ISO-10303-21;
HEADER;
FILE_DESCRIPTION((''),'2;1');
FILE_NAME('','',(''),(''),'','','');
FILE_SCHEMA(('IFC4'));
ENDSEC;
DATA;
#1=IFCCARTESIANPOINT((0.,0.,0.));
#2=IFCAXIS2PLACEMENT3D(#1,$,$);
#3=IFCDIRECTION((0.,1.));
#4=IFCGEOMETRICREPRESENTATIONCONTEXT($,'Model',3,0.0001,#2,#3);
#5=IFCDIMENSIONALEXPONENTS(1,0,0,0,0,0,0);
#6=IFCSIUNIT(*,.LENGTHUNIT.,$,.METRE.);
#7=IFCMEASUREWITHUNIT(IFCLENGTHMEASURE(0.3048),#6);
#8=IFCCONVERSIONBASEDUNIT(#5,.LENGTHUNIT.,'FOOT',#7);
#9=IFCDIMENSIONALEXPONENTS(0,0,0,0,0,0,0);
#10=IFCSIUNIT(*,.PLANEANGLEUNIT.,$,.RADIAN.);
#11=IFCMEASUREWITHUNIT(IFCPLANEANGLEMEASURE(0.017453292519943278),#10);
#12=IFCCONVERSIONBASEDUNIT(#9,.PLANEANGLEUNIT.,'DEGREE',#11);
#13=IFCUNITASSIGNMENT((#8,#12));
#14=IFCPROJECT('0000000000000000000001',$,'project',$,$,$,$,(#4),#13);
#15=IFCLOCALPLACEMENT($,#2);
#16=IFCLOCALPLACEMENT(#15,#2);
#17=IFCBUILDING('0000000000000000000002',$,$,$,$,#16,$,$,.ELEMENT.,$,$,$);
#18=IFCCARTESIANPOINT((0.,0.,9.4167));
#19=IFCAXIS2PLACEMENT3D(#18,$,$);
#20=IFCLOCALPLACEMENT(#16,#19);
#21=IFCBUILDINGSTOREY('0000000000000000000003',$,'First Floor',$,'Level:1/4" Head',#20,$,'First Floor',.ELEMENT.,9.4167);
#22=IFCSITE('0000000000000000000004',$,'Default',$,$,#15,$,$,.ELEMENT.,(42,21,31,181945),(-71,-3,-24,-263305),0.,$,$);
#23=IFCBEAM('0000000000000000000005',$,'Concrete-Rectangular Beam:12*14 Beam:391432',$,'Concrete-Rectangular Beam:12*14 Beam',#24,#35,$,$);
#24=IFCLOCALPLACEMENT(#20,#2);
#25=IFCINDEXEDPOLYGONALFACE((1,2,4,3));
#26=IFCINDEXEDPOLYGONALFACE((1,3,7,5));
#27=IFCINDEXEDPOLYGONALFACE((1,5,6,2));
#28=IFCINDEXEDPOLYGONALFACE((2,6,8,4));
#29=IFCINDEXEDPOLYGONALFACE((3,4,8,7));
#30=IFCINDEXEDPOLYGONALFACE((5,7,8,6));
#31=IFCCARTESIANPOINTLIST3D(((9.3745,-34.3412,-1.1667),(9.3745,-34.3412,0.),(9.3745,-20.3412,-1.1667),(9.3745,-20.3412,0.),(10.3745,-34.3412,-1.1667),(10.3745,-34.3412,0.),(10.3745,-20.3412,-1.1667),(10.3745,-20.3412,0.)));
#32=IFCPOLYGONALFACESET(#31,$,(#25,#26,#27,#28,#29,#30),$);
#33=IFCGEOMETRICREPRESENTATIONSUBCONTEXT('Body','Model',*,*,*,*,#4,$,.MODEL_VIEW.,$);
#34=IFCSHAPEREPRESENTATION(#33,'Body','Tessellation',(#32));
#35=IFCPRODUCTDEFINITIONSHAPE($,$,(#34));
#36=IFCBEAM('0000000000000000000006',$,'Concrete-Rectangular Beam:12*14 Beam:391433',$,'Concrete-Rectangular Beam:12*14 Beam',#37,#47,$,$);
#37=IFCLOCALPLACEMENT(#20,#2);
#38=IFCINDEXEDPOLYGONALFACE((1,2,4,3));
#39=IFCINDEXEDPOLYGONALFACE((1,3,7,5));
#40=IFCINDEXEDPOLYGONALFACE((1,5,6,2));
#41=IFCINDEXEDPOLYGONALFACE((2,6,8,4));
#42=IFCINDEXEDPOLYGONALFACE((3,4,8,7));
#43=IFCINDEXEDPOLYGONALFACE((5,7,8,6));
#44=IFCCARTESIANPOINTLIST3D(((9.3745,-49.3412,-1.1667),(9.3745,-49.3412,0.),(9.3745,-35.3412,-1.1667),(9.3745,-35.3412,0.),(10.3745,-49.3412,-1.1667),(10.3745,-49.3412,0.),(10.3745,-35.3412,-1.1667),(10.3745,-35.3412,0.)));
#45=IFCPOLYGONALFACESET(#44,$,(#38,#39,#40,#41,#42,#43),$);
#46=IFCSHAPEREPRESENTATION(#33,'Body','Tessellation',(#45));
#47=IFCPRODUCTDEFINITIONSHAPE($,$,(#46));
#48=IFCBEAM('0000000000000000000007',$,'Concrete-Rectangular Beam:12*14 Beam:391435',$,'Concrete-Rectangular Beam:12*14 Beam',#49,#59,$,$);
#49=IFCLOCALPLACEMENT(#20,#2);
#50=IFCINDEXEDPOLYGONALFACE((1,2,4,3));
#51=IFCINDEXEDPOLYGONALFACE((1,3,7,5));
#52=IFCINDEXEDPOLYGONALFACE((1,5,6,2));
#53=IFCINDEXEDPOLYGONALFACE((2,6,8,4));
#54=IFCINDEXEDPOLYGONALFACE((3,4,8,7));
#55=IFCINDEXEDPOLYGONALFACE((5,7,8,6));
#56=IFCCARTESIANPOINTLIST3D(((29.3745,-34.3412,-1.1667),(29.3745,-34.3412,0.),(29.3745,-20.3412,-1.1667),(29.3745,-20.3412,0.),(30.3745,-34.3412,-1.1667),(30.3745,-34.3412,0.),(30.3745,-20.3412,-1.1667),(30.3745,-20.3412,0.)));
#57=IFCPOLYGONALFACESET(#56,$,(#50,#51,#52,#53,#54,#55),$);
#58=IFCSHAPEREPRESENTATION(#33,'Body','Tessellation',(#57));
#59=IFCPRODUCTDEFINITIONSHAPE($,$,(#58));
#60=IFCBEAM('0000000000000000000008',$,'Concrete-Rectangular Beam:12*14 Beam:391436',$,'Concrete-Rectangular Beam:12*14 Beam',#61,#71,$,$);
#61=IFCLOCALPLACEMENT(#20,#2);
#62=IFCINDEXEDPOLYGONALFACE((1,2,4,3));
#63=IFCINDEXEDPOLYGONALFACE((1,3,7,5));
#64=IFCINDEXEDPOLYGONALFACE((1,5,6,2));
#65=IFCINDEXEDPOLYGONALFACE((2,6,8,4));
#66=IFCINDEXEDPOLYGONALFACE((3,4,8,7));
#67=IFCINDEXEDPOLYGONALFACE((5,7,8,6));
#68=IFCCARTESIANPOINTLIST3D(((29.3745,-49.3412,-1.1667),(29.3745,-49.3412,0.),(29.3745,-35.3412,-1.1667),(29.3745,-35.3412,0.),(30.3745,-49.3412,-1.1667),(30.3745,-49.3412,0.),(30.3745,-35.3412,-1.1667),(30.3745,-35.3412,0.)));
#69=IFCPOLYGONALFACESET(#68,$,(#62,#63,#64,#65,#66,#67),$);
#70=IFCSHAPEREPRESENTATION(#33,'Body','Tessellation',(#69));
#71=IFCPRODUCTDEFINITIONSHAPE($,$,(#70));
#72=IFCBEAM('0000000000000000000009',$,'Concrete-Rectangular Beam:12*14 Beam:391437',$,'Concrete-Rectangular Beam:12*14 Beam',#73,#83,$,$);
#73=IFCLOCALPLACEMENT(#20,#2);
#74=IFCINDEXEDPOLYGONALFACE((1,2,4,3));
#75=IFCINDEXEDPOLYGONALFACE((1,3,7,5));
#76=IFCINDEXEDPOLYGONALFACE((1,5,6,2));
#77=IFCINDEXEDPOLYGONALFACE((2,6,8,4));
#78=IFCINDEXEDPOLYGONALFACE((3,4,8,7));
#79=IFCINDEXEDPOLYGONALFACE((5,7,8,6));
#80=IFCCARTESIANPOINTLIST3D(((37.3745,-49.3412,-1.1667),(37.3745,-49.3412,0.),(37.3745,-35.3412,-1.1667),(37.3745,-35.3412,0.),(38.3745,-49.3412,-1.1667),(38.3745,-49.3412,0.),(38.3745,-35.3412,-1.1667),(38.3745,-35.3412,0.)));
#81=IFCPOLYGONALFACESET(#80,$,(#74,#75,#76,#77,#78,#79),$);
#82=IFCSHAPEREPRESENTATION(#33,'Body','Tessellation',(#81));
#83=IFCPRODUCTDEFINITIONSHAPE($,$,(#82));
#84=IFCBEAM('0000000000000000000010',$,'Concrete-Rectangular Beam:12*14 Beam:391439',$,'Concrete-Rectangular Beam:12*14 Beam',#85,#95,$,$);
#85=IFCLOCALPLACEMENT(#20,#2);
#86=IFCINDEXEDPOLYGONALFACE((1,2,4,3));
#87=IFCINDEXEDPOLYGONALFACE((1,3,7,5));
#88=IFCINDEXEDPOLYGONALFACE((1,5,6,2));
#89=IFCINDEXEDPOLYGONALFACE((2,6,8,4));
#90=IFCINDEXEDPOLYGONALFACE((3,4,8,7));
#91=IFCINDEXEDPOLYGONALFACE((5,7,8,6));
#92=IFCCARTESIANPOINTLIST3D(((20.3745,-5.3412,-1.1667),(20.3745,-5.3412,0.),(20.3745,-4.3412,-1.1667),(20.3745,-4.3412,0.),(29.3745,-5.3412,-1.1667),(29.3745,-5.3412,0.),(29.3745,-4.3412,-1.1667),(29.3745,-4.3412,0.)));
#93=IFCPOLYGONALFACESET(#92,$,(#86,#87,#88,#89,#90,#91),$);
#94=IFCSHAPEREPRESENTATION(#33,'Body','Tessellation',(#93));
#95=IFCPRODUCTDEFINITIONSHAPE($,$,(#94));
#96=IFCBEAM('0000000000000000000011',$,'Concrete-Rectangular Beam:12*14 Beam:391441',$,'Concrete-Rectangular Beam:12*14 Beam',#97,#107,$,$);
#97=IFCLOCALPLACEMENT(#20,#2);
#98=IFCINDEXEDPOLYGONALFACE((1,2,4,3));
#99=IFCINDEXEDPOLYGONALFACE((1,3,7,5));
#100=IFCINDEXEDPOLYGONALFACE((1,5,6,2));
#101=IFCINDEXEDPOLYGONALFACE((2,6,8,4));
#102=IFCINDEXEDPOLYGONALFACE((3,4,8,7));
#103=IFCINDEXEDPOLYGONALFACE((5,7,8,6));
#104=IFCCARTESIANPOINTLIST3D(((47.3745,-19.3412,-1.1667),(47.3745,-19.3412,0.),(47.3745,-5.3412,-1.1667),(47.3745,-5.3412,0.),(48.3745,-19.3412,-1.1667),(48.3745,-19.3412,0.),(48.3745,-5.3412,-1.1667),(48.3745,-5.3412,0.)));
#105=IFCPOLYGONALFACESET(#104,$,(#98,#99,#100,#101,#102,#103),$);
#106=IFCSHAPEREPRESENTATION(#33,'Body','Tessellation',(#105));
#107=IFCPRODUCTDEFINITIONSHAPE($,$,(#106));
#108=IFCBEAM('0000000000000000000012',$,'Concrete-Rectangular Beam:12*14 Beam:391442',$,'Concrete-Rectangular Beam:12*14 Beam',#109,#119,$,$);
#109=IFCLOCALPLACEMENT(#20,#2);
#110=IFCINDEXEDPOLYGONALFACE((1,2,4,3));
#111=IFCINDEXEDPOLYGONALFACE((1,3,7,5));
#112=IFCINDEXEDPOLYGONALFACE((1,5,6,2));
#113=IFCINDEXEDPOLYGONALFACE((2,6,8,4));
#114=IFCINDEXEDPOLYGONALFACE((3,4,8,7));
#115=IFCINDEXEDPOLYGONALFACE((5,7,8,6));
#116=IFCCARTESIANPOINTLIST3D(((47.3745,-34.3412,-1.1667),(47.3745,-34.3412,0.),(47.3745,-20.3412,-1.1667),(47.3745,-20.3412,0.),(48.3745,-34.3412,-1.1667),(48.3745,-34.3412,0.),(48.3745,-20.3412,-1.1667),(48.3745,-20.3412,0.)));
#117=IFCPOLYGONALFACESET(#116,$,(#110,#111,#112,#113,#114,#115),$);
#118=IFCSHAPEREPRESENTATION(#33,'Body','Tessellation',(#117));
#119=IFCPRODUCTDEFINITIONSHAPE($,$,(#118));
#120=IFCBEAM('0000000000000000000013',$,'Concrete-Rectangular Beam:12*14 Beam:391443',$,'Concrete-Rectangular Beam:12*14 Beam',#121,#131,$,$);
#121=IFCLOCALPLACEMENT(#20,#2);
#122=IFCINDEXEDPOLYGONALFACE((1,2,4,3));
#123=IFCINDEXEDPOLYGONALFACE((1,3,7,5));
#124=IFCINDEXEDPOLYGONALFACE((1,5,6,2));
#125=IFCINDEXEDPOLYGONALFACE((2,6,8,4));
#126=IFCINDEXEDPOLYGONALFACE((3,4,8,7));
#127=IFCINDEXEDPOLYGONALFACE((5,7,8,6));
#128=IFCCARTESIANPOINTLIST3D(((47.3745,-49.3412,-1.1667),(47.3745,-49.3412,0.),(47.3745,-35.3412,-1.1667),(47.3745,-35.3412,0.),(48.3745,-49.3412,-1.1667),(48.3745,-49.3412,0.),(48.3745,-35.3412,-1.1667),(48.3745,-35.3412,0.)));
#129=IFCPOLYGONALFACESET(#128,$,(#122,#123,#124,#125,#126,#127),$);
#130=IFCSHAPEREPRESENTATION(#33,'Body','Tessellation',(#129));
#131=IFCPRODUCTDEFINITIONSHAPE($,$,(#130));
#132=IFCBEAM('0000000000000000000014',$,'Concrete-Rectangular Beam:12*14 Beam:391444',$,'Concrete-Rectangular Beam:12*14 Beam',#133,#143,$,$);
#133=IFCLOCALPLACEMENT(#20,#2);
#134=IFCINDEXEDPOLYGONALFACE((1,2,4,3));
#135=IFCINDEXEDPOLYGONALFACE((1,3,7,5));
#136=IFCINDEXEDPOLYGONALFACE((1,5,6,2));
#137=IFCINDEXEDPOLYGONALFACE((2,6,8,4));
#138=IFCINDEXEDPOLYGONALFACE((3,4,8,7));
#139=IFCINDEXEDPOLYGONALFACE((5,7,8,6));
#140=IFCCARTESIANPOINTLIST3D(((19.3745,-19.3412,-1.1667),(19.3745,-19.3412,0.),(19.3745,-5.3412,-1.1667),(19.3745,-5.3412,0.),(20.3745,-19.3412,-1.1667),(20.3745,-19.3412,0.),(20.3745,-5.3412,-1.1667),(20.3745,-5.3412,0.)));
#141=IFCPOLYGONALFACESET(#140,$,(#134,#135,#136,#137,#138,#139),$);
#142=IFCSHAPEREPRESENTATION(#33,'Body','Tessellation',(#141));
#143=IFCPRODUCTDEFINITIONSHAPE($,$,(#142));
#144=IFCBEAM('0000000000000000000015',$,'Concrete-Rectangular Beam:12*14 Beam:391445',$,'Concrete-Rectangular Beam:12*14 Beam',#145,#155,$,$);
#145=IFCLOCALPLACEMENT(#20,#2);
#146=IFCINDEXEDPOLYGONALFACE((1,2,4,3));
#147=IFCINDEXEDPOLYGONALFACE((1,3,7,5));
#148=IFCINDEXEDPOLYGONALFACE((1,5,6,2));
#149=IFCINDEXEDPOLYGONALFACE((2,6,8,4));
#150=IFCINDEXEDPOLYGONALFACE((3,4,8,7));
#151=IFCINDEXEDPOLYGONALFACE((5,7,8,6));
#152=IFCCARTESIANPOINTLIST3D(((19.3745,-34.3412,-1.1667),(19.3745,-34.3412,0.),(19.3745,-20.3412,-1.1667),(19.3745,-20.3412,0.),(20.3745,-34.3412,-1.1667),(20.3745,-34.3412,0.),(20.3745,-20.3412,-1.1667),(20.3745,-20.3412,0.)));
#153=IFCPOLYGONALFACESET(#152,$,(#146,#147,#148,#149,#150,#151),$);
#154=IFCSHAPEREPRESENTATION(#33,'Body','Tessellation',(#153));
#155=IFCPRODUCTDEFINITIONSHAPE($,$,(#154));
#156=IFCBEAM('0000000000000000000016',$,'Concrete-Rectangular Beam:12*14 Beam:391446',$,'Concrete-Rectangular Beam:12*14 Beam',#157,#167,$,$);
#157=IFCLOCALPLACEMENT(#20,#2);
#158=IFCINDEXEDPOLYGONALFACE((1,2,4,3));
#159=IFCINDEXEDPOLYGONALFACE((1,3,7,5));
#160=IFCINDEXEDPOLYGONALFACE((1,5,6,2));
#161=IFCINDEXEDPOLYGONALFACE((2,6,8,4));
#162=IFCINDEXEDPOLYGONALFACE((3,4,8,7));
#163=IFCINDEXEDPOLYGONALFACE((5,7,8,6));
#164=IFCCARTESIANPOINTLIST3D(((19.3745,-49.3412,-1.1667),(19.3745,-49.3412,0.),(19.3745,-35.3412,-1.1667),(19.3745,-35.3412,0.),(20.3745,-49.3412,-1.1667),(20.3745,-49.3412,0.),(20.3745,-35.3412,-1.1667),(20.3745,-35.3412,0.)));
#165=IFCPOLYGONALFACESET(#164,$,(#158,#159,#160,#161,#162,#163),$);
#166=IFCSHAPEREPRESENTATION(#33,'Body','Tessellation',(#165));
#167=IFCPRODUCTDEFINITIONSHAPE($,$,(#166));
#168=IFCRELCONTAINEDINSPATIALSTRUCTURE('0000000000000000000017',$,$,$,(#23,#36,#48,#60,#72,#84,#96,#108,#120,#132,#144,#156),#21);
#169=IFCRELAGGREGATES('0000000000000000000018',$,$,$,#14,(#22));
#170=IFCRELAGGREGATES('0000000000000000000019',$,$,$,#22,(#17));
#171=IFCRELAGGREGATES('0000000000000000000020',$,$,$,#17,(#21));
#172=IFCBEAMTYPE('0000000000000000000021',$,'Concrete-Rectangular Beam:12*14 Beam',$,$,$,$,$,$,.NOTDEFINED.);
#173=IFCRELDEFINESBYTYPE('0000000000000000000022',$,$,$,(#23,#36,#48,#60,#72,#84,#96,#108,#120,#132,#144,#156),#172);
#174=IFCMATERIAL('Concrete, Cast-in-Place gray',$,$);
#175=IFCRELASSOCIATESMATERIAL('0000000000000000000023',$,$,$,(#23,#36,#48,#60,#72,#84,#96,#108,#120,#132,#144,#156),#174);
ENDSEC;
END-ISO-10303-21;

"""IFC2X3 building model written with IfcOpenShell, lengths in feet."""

from ifc_helpers import new_model, entity, si_unit, converted_unit, direction, frame, frame_2d, origin, place, context, subcontext, project, spatial, rectangle, extrude, material, type_object, element, save


model = new_model("IFC2X3")

# Units and contexts
model_context = context("Model", 3, precision=0.0001, world=origin(), true_north=direction((0.0, 1.0)))
body_context = subcontext(model_context, "Body", "Model", "MODEL_VIEW")
ifc_project = project(units=[converted_unit("LENGTHUNIT", "FOOT", entity("IfcLengthMeasure", 0.3048), si_unit("LENGTHUNIT", "METRE"), dimensions=[1, 0, 0, 0, 0, 0, 0]), converted_unit("PLANEANGLEUNIT", "DEGREE", entity("IfcPlaneAngleMeasure", 0.017453292519943278), si_unit("PLANEANGLEUNIT", "RADIAN"), dimensions=[0, 0, 0, 0, 0, 0, 0])], contexts=[model_context])

# Site, building, storey
site_placement = place(None, origin())
site = spatial("IfcSite", under=ifc_project, at=site_placement, Name="Default", CompositionType="ELEMENT", RefLatitude=(42, 21, 31, 181945), RefLongitude=(-71, -3, -24, -263305), RefElevation=0.0)
building_placement = place(site_placement, origin())
building = spatial("IfcBuilding", under=site, at=building_placement, CompositionType="ELEMENT")
storey_placement = place(building_placement, frame((0.0, 0.0, 9.4167)))
storey = spatial("IfcBuildingStorey", under=building, at=storey_placement, Name="First Floor", ObjectType="Level:1/4\" Head", LongName="First Floor", CompositionType="ELEMENT", Elevation=9.4167)

# Beams
ifc_material = material(Name="Concrete, Cast-in-Place gray")
beam_type = type_object("IfcBeamType", Name="Concrete-Rectangular Beam:12*14 Beam", PredefinedType="NOTDEFINED")
beam_1_placement = place(storey_placement, frame((9.8745, -19.8412, 0.0), z_axis=(0.0, 0.0, 1.0), x_axis=(0.0, -1.0, 0.0)))
element("IfcBeam", 1, at=beam_1_placement, inside=storey, type_object=beam_type, material=ifc_material, Name="Concrete-Rectangular Beam:12*14 Beam:391432", ObjectType="Concrete-Rectangular Beam:12*14 Beam", context=body_context, shape_type="SweptSolid", body=[
    extrude(rectangle(XDim=1.1667, YDim=1.0, at=frame_2d((0.0, 0.0), x_axis=(1.0, 0.0))), frame((0.5, 0.0, -0.5833), z_axis=(1.0, 0.0, 0.0), x_axis=(0.0, 0.0, -1.0)), (0.0, 0.0, 1.0), 14.0),
])
beam_2_placement = place(storey_placement, frame((9.8745, -34.8412, 0.0), z_axis=(0.0, 0.0, 1.0), x_axis=(0.0, -1.0, 0.0)))
element("IfcBeam", 2, at=beam_2_placement, inside=storey, type_object=beam_type, material=ifc_material, Name="Concrete-Rectangular Beam:12*14 Beam:391433", ObjectType="Concrete-Rectangular Beam:12*14 Beam", context=body_context, shape_type="SweptSolid", body=[
    extrude(rectangle(XDim=1.1667, YDim=1.0, at=frame_2d((0.0, 0.0), x_axis=(1.0, 0.0))), frame((0.5, 0.0, -0.5833), z_axis=(1.0, 0.0, 0.0), x_axis=(0.0, 0.0, -1.0)), (0.0, 0.0, 1.0), 14.0),
])
beam_3_placement = place(storey_placement, frame((29.8745, -19.8412, 0.0), z_axis=(0.0, 0.0, 1.0), x_axis=(0.0, -1.0, 0.0)))
element("IfcBeam", 3, at=beam_3_placement, inside=storey, type_object=beam_type, material=ifc_material, Name="Concrete-Rectangular Beam:12*14 Beam:391435", ObjectType="Concrete-Rectangular Beam:12*14 Beam", context=body_context, shape_type="SweptSolid", body=[
    extrude(rectangle(XDim=1.1667, YDim=1.0, at=frame_2d((0.0, 0.0), x_axis=(1.0, 0.0))), frame((0.5, 0.0, -0.5833), z_axis=(1.0, 0.0, 0.0), x_axis=(0.0, 0.0, -1.0)), (0.0, 0.0, 1.0), 14.0),
])
beam_4_placement = place(storey_placement, frame((29.8745, -34.8412, 0.0), z_axis=(0.0, 0.0, 1.0), x_axis=(0.0, -1.0, 0.0)))
element("IfcBeam", 4, at=beam_4_placement, inside=storey, type_object=beam_type, material=ifc_material, Name="Concrete-Rectangular Beam:12*14 Beam:391436", ObjectType="Concrete-Rectangular Beam:12*14 Beam", context=body_context, shape_type="SweptSolid", body=[
    extrude(rectangle(XDim=1.1667, YDim=1.0, at=frame_2d((0.0, 0.0), x_axis=(1.0, 0.0))), frame((0.5, 0.0, -0.5833), z_axis=(1.0, 0.0, 0.0), x_axis=(0.0, 0.0, -1.0)), (0.0, 0.0, 1.0), 14.0),
])
beam_5_placement = place(storey_placement, frame((37.8745, -34.8412, 0.0), z_axis=(0.0, 0.0, 1.0), x_axis=(0.0, -1.0, 0.0)))
element("IfcBeam", 5, at=beam_5_placement, inside=storey, type_object=beam_type, material=ifc_material, Name="Concrete-Rectangular Beam:12*14 Beam:391437", ObjectType="Concrete-Rectangular Beam:12*14 Beam", context=body_context, shape_type="SweptSolid", body=[
    extrude(rectangle(XDim=1.1667, YDim=1.0, at=frame_2d((0.0, 0.0), x_axis=(1.0, 0.0))), frame((0.5, 0.0, -0.5833), z_axis=(1.0, 0.0, 0.0), x_axis=(0.0, 0.0, -1.0)), (0.0, 0.0, 1.0), 14.0),
])
beam_6_placement = place(storey_placement, frame((19.8745, -4.8412, 0.0)))
element("IfcBeam", 6, at=beam_6_placement, inside=storey, type_object=beam_type, material=ifc_material, Name="Concrete-Rectangular Beam:12*14 Beam:391439", ObjectType="Concrete-Rectangular Beam:12*14 Beam", context=body_context, shape_type="SweptSolid", body=[
    extrude(rectangle(XDim=1.1667, YDim=1.0, at=frame_2d((0.0, 0.0), x_axis=(1.0, 0.0))), frame((0.5, 0.0, -0.5833), z_axis=(1.0, 0.0, 0.0), x_axis=(0.0, 0.0, -1.0)), (0.0, 0.0, 1.0), 9.0),
])
beam_7_placement = place(storey_placement, frame((47.8745, -4.8412, 0.0), z_axis=(0.0, 0.0, 1.0), x_axis=(0.0, -1.0, 0.0)))
element("IfcBeam", 7, at=beam_7_placement, inside=storey, type_object=beam_type, material=ifc_material, Name="Concrete-Rectangular Beam:12*14 Beam:391441", ObjectType="Concrete-Rectangular Beam:12*14 Beam", context=body_context, shape_type="SweptSolid", body=[
    extrude(rectangle(XDim=1.1667, YDim=1.0, at=frame_2d((0.0, 0.0), x_axis=(1.0, 0.0))), frame((0.5, 0.0, -0.5833), z_axis=(1.0, 0.0, 0.0), x_axis=(0.0, 0.0, -1.0)), (0.0, 0.0, 1.0), 14.0),
])
beam_8_placement = place(storey_placement, frame((47.8745, -19.8412, 0.0), z_axis=(0.0, 0.0, 1.0), x_axis=(0.0, -1.0, 0.0)))
element("IfcBeam", 8, at=beam_8_placement, inside=storey, type_object=beam_type, material=ifc_material, Name="Concrete-Rectangular Beam:12*14 Beam:391442", ObjectType="Concrete-Rectangular Beam:12*14 Beam", context=body_context, shape_type="SweptSolid", body=[
    extrude(rectangle(XDim=1.1667, YDim=1.0, at=frame_2d((0.0, 0.0), x_axis=(1.0, 0.0))), frame((0.5, 0.0, -0.5833), z_axis=(1.0, 0.0, 0.0), x_axis=(0.0, 0.0, -1.0)), (0.0, 0.0, 1.0), 14.0),
])
beam_9_placement = place(storey_placement, frame((47.8745, -34.8412, 0.0), z_axis=(0.0, 0.0, 1.0), x_axis=(0.0, -1.0, 0.0)))
element("IfcBeam", 9, at=beam_9_placement, inside=storey, type_object=beam_type, material=ifc_material, Name="Concrete-Rectangular Beam:12*14 Beam:391443", ObjectType="Concrete-Rectangular Beam:12*14 Beam", context=body_context, shape_type="SweptSolid", body=[
    extrude(rectangle(XDim=1.1667, YDim=1.0, at=frame_2d((0.0, 0.0), x_axis=(1.0, 0.0))), frame((0.5, 0.0, -0.5833), z_axis=(1.0, 0.0, 0.0), x_axis=(0.0, 0.0, -1.0)), (0.0, 0.0, 1.0), 14.0),
])
beam_10_placement = place(storey_placement, frame((19.8745, -4.8412, 0.0), z_axis=(0.0, 0.0, 1.0), x_axis=(0.0, -1.0, 0.0)))
element("IfcBeam", 10, at=beam_10_placement, inside=storey, type_object=beam_type, material=ifc_material, Name="Concrete-Rectangular Beam:12*14 Beam:391444", ObjectType="Concrete-Rectangular Beam:12*14 Beam", context=body_context, shape_type="SweptSolid", body=[
    extrude(rectangle(XDim=1.1667, YDim=1.0, at=frame_2d((0.0, 0.0), x_axis=(1.0, 0.0))), frame((0.5, 0.0, -0.5833), z_axis=(1.0, 0.0, 0.0), x_axis=(0.0, 0.0, -1.0)), (0.0, 0.0, 1.0), 14.0),
])
beam_11_placement = place(storey_placement, frame((19.8745, -19.8412, 0.0), z_axis=(0.0, 0.0, 1.0), x_axis=(0.0, -1.0, 0.0)))
element("IfcBeam", 11, at=beam_11_placement, inside=storey, type_object=beam_type, material=ifc_material, Name="Concrete-Rectangular Beam:12*14 Beam:391445", ObjectType="Concrete-Rectangular Beam:12*14 Beam", context=body_context, shape_type="SweptSolid", body=[
    extrude(rectangle(XDim=1.1667, YDim=1.0, at=frame_2d((0.0, 0.0), x_axis=(1.0, 0.0))), frame((0.5, 0.0, -0.5833), z_axis=(1.0, 0.0, 0.0), x_axis=(0.0, 0.0, -1.0)), (0.0, 0.0, 1.0), 14.0),
])
beam_12_placement = place(storey_placement, frame((19.8745, -34.8412, 0.0), z_axis=(0.0, 0.0, 1.0), x_axis=(0.0, -1.0, 0.0)))
element("IfcBeam", 12, at=beam_12_placement, inside=storey, type_object=beam_type, material=ifc_material, Name="Concrete-Rectangular Beam:12*14 Beam:391446", ObjectType="Concrete-Rectangular Beam:12*14 Beam", context=body_context, shape_type="SweptSolid", body=[
    extrude(rectangle(XDim=1.1667, YDim=1.0, at=frame_2d((0.0, 0.0), x_axis=(1.0, 0.0))), frame((0.5, 0.0, -0.5833), z_axis=(1.0, 0.0, 0.0), x_axis=(0.0, 0.0, -1.0)), (0.0, 0.0, 1.0), 14.0),
])

save(model, "model.ifc")
